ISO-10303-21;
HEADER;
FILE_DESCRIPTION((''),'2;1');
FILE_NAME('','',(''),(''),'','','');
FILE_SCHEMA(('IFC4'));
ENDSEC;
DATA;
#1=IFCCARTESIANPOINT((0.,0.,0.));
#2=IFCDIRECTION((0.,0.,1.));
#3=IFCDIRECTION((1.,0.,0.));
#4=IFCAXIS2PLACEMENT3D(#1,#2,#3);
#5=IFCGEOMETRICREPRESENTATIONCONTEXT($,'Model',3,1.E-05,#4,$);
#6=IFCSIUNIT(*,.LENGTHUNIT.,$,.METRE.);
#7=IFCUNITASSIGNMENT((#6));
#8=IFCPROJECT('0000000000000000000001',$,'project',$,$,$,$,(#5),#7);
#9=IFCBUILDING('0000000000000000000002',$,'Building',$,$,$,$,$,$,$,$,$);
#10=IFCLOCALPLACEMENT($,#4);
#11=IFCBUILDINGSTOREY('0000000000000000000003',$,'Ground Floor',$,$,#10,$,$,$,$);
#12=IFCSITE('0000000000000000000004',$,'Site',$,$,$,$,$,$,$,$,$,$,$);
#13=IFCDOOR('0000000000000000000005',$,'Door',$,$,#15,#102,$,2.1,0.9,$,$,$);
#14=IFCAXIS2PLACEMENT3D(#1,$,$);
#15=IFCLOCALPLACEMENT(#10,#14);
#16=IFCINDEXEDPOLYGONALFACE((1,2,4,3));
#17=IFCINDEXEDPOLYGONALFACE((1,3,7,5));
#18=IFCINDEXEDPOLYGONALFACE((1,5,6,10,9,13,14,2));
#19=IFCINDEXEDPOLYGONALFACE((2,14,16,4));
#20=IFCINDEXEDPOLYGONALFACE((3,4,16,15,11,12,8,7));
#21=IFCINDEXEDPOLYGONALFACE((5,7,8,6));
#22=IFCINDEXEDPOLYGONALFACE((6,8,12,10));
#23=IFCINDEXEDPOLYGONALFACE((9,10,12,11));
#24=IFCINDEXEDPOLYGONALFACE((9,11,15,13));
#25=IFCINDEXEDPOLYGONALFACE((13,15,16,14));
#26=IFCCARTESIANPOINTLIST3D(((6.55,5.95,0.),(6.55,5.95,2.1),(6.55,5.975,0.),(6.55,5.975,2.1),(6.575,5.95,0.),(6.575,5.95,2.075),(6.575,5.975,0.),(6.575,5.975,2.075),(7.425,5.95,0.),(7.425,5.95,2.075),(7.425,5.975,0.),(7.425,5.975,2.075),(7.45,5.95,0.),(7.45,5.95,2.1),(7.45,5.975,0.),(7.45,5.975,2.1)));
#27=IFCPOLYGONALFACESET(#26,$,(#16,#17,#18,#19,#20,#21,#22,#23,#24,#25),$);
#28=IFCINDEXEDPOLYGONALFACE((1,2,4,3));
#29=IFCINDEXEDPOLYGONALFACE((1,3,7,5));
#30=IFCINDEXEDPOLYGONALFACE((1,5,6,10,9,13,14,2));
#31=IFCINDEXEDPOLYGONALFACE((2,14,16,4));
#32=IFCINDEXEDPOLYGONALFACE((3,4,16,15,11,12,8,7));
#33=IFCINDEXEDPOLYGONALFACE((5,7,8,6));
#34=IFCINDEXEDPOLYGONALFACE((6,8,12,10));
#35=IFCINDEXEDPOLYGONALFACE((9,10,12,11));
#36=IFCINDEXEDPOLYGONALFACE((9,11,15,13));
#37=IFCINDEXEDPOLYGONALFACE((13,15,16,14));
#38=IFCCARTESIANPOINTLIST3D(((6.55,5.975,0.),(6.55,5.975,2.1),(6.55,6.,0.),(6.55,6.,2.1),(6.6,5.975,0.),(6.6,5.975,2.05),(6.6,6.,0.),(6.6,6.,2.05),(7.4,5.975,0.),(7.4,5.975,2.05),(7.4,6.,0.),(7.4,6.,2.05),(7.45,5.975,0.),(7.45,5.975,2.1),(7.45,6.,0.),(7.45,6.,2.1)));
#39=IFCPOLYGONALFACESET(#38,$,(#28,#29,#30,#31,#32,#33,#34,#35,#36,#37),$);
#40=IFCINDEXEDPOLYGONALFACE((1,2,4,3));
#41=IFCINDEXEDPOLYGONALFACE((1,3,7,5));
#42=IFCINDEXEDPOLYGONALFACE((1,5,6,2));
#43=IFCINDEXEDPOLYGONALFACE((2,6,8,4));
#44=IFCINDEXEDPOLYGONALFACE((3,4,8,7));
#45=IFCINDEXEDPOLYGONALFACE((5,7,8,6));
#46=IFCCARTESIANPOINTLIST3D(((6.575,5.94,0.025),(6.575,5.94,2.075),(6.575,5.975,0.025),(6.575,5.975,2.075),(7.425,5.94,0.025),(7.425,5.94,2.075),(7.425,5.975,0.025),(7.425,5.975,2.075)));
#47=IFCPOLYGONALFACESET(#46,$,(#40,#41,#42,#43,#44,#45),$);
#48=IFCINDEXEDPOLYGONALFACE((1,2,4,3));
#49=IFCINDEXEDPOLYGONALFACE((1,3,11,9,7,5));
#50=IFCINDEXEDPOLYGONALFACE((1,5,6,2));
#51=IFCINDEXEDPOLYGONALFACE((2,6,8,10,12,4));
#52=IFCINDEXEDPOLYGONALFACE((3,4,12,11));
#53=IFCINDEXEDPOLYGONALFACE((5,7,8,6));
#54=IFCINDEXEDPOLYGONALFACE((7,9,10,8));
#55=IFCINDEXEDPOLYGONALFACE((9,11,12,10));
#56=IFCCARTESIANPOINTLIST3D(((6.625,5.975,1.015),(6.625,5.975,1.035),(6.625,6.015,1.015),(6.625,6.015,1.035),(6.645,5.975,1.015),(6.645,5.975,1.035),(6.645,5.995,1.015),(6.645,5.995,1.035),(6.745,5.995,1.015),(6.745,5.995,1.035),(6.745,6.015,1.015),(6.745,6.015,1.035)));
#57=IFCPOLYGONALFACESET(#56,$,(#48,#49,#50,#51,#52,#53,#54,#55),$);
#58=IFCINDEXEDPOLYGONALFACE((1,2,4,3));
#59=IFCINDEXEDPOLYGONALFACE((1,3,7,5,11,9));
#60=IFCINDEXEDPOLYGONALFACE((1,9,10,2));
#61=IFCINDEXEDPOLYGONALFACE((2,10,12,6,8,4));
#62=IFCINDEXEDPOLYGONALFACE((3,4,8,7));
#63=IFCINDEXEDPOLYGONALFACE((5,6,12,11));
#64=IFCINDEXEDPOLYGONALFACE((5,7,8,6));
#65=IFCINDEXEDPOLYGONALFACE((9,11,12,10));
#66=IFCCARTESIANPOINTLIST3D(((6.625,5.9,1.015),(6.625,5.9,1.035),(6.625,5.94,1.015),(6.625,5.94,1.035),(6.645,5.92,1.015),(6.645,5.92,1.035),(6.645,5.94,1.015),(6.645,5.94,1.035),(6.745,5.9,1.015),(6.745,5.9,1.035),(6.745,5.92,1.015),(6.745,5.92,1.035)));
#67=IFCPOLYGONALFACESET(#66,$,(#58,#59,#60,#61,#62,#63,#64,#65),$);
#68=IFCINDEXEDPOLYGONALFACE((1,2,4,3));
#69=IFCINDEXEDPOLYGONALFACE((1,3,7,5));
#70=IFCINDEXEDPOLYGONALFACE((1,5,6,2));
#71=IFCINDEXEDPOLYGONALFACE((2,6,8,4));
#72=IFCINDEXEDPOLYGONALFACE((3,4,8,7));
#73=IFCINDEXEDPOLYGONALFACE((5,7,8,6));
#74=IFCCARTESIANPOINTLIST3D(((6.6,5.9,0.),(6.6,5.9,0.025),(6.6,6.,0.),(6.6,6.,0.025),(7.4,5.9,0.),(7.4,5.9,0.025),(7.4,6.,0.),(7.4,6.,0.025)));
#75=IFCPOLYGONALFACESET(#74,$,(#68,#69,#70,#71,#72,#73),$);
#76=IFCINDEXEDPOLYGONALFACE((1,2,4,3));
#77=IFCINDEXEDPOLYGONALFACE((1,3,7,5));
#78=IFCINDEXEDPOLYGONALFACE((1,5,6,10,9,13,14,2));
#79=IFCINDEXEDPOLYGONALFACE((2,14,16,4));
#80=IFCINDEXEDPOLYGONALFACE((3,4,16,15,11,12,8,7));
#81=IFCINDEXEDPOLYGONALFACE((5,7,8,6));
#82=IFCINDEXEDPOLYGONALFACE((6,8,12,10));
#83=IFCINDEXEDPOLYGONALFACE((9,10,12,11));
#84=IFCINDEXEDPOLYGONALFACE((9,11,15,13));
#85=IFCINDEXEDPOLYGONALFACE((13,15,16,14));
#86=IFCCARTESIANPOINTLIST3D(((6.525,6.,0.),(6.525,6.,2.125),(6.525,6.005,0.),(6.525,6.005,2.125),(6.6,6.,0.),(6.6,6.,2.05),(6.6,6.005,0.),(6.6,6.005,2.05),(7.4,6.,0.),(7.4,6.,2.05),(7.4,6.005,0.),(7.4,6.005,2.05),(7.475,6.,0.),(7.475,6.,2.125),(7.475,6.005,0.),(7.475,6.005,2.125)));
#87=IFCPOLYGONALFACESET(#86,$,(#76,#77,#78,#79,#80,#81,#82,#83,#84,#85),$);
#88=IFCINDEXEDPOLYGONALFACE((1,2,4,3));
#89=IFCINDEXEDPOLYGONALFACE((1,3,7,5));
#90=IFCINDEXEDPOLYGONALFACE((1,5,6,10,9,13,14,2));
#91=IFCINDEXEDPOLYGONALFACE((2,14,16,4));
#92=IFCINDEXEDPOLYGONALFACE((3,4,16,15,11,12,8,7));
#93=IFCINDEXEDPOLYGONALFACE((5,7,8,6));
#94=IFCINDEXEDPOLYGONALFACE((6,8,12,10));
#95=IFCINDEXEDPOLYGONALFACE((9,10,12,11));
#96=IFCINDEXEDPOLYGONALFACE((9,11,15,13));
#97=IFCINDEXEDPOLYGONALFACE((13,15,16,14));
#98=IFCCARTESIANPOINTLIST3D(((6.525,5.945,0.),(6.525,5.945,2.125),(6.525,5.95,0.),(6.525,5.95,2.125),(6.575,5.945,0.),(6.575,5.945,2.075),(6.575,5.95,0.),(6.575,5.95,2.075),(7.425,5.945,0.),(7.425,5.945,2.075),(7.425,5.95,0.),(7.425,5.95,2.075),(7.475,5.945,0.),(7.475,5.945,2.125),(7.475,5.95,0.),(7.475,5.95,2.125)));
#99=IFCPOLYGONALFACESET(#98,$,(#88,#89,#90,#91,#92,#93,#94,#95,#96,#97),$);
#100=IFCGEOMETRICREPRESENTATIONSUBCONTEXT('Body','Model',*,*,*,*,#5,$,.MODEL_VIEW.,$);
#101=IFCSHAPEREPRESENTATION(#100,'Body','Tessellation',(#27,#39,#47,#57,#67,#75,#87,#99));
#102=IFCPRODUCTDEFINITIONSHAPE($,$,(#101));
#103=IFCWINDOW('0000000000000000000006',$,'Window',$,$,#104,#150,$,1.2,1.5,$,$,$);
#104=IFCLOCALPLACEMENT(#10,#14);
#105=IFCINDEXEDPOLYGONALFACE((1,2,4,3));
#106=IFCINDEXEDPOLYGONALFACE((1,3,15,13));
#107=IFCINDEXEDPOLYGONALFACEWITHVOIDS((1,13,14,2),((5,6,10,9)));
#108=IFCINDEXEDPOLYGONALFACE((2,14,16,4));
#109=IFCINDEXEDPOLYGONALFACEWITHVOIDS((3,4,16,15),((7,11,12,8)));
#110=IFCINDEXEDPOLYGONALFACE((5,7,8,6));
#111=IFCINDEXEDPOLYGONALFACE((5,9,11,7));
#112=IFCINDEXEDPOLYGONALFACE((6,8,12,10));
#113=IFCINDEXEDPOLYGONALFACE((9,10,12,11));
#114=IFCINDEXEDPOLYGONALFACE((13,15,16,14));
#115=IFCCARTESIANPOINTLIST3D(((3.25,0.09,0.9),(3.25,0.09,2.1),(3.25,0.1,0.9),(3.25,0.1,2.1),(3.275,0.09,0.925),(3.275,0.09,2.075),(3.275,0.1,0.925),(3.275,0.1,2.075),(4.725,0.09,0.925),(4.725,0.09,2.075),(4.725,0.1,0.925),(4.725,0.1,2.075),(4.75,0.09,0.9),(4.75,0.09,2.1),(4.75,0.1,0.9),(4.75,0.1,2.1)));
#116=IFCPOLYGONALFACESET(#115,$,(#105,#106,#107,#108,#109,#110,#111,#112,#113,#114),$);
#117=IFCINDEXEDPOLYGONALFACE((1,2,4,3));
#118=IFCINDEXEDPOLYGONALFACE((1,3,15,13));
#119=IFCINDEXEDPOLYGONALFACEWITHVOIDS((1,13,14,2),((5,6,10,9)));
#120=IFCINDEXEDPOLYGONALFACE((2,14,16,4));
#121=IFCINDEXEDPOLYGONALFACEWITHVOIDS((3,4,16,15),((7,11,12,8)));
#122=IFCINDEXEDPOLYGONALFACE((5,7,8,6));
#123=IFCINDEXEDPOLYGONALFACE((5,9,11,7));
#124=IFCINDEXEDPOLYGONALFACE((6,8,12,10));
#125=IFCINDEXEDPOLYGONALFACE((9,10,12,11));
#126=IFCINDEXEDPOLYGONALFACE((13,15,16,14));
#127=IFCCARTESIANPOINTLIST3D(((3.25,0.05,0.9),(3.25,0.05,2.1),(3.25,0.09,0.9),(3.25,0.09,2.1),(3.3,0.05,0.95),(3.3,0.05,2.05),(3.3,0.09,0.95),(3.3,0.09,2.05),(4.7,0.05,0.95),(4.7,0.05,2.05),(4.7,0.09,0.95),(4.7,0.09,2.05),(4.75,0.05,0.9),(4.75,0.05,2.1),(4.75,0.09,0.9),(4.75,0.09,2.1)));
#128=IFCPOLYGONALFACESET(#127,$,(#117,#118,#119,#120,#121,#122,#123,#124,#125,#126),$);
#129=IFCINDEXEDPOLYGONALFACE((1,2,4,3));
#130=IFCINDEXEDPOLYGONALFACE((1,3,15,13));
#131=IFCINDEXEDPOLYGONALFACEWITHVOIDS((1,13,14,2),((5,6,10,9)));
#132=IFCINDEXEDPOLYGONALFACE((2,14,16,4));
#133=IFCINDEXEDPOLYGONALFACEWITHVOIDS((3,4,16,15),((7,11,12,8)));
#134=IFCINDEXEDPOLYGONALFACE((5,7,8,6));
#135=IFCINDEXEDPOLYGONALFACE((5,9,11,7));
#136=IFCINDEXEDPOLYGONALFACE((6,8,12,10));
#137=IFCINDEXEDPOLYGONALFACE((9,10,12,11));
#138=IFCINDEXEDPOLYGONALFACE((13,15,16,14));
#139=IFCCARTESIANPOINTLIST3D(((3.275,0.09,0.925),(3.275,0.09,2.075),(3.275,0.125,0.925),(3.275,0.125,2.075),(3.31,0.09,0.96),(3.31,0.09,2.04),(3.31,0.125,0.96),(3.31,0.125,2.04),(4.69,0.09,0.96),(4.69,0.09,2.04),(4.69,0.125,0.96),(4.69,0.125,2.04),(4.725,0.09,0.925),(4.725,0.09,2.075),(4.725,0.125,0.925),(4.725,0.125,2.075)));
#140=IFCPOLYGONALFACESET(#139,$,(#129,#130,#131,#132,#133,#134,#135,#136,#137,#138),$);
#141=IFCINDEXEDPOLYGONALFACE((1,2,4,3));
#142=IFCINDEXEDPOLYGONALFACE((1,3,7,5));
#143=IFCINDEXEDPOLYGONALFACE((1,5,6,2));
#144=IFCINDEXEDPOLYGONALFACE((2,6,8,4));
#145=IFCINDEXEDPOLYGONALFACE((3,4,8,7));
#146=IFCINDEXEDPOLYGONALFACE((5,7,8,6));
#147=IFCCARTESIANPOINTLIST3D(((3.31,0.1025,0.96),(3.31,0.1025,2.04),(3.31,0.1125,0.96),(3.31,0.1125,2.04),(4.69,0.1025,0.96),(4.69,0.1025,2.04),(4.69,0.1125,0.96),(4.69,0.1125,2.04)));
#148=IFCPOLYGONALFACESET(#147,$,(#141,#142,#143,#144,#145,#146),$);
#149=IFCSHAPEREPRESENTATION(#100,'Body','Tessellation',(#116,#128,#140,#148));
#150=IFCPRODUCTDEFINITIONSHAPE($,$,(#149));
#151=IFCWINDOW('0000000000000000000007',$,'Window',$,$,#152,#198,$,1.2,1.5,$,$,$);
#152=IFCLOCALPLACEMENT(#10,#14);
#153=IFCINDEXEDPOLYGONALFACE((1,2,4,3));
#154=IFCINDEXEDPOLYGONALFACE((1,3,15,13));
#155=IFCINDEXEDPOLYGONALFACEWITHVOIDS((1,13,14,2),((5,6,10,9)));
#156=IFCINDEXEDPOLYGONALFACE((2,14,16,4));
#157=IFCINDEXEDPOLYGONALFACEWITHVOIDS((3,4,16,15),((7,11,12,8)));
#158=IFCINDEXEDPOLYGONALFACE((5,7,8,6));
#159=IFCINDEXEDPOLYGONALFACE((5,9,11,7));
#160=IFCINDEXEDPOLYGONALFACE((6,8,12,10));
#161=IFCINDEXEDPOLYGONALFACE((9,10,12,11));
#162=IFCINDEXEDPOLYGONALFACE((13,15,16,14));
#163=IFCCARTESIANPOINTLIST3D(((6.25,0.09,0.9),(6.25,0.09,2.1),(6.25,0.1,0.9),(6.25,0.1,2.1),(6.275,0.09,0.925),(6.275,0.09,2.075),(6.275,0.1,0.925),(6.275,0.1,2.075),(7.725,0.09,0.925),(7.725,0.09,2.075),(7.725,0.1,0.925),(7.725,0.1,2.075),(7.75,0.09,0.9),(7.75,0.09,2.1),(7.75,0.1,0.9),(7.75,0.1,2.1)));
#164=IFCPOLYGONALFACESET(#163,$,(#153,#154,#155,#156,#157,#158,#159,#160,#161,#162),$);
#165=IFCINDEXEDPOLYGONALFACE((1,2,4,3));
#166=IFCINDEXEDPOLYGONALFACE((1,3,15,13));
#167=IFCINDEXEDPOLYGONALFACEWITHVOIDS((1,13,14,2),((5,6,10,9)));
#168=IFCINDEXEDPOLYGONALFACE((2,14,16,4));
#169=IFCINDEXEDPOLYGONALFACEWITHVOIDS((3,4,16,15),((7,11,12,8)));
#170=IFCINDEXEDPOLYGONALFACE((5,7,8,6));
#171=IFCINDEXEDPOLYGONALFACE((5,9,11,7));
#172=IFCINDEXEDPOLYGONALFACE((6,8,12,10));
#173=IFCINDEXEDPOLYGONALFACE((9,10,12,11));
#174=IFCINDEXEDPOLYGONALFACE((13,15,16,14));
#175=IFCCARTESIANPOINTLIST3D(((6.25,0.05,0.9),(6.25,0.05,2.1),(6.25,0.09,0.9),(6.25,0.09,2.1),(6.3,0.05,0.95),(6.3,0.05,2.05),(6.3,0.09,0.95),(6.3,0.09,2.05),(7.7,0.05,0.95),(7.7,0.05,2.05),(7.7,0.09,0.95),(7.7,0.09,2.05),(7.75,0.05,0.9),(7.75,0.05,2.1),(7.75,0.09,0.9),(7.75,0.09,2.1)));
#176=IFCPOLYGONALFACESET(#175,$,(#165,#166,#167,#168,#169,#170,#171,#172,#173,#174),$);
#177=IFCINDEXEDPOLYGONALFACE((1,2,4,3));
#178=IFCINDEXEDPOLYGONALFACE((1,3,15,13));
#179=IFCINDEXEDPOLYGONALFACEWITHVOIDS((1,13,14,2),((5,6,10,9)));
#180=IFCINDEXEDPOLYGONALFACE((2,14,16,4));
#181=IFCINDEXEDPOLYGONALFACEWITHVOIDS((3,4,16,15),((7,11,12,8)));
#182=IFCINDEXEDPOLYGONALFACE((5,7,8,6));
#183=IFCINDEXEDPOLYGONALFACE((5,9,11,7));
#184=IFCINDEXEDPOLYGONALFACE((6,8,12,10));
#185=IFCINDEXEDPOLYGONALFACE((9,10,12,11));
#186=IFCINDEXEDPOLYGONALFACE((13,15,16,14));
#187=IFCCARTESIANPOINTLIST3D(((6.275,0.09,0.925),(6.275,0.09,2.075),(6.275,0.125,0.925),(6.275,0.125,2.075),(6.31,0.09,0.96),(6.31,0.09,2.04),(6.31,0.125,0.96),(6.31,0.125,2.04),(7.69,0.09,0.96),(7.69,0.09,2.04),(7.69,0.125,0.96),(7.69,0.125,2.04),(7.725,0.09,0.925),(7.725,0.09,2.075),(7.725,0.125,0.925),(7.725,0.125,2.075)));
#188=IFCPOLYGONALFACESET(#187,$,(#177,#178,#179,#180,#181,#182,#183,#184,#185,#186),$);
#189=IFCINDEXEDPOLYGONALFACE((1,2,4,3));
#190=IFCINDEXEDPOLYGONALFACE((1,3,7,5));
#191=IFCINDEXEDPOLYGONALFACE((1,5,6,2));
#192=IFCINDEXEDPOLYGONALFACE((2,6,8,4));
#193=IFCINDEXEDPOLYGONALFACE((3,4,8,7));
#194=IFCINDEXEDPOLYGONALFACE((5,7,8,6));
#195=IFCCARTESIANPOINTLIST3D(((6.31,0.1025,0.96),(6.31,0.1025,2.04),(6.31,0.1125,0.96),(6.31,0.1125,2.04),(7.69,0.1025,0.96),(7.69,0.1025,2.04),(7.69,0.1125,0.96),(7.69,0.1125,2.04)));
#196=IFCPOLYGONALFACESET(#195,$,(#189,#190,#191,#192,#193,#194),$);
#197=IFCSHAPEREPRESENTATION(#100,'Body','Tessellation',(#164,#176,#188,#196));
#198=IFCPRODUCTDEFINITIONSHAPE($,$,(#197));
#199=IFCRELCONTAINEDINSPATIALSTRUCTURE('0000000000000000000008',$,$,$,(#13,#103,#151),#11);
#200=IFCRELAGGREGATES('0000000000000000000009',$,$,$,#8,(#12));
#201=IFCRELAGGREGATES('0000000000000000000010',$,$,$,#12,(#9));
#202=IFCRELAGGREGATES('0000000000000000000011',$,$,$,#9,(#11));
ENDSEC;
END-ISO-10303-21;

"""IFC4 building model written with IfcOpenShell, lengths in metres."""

from ifc_helpers import new_model, si_unit, frame, origin_with_axes, place, context, subcontext, project, spatial, line, indexed_curve, outline, extrude, element, save


model = new_model("IFC4")

# Units and contexts
model_context = context("Model", 3, precision=1e-05, world=origin_with_axes())
body_context = subcontext(model_context, "Body", "Model", "MODEL_VIEW")
ifc_project = project(units=[si_unit("LENGTHUNIT", "METRE")], contexts=[model_context])

# Site, building, storey
site = spatial("IfcSite", under=ifc_project, Name="Site")
building = spatial("IfcBuilding", under=site, Name="Building")
storey_placement = place(None, origin_with_axes())
storey = spatial("IfcBuildingStorey", under=building, at=storey_placement, Name="Ground Floor")

# Door
door_1_placement = place(storey_placement, frame((7.45, 6.0, 0.0), z_axis=(0.0, 0.0, 1.0), x_axis=(-1.0, 0.0, 0.0)))
element("IfcDoor", 1, at=door_1_placement, inside=storey, Name="Door", OverallHeight=2.1, OverallWidth=0.9, context=body_context, shape_type="SweptSolid", body=[
    extrude(outline(indexed_curve([(0.0, 0.0), (0.0, 2.1), (0.9, 2.1), (0.9, 0.0), (0.875, 0.0), (0.875, 2.075), (0.025, 2.075), (0.025, 0.0)], segments=[line(1, 2, 3, 4, 5, 6, 7, 8, 1)])), frame((0.0, 0.025, 0.0), z_axis=(0.0, -1.0, 0.0), x_axis=(1.0, 0.0, 0.0)), (0.0, 0.0, -1.0), 0.025),
    extrude(outline(indexed_curve([(0.0, 0.0), (0.0, 2.1), (0.9, 2.1), (0.9, 0.0), (0.85, 0.0), (0.85, 2.05), (0.05, 2.05), (0.05, 0.0)], segments=[line(1, 2, 3, 4, 5, 6, 7, 8, 1)])), frame((0.0, 0.0, 0.0), z_axis=(0.0, -1.0, 0.0), x_axis=(1.0, 0.0, 0.0)), (0.0, 0.0, -1.0), 0.025),
    extrude(outline(indexed_curve([(0.0, 0.0), (0.85, 0.0), (0.85, 0.035), (0.0, 0.035)], segments=[line(1, 2, 3, 4, 1)])), frame((0.025, 0.025, 0.025), z_axis=(0.0, 0.0, 1.0), x_axis=(1.0, 0.0, 0.0)), (0.0, 0.0, 1.0), 2.05),
    extrude(outline(indexed_curve([(0.0, 0.0), (0.0, -0.04), (-0.12, -0.04), (-0.12, -0.02), (-0.02, -0.02), (-0.02, 0.0)], segments=[line(1, 2, 3, 4, 5, 6, 1)])), frame((0.825, 0.025, 1.015), z_axis=(0.0, 0.0, 1.0), x_axis=(1.0, 0.0, 0.0)), (0.0, 0.0, 1.0), 0.02),
    extrude(outline(indexed_curve([(0.0, 0.0), (0.0, 0.04), (-0.12, 0.04), (-0.12, 0.02), (-0.02, 0.02), (-0.02, 0.0)], segments=[line(1, 2, 3, 4, 5, 6, 1)])), frame((0.825, 0.06, 1.015), z_axis=(0.0, 0.0, 1.0), x_axis=(1.0, 0.0, 0.0)), (0.0, 0.0, 1.0), 0.02),
    extrude(outline(indexed_curve([(0.0, 0.0), (0.8, 0.0), (0.8, 0.1), (0.0, 0.1)], segments=[line(1, 2, 3, 4, 1)])), frame((0.05, 0.0, 0.0), z_axis=(0.0, 0.0, 1.0), x_axis=(1.0, 0.0, 0.0)), (0.0, 0.0, 1.0), 0.025),
    extrude(outline(indexed_curve([(0.0, 0.0), (0.0, 2.125), (0.95, 2.125), (0.95, 0.0), (0.875, 0.0), (0.875, 2.05), (0.075, 2.05), (0.075, 0.0)], segments=[line(1, 2, 3, 4, 5, 6, 7, 8, 1)])), frame((-0.025, -0.005, 0.0), z_axis=(0.0, -1.0, 0.0), x_axis=(1.0, 0.0, 0.0)), (0.0, 0.0, -1.0), 0.005),
    extrude(outline(indexed_curve([(0.0, 0.0), (0.0, 2.125), (0.95, 2.125), (0.95, 0.0), (0.9, 0.0), (0.9, 2.075), (0.05, 2.075), (0.05, 0.0)], segments=[line(1, 2, 3, 4, 5, 6, 7, 8, 1)])), frame((-0.025, 0.05, 0.0), z_axis=(0.0, -1.0, 0.0), x_axis=(1.0, 0.0, 0.0)), (0.0, 0.0, -1.0), 0.005),
])

# Windows
for number, where, z_axis, x_axis, name in (
    (2, (3.25, 0.0, 0.9), (0.0, 0.0, 1.0), (1.0, 0.0, 0.0), "Window"),
    (3, (6.25, 0.0, 0.9), (0.0, 0.0, 1.0), (1.0, 0.0, 0.0), "Window"),
):
    element("IfcWindow", number, at=place(storey_placement, frame(where, z_axis=z_axis, x_axis=x_axis)), inside=storey, Name=name, OverallHeight=1.2, OverallWidth=1.5, context=body_context, shape_type="SweptSolid", body=[
        extrude(outline(indexed_curve([(0.0, 0.0), (1.5, 0.0), (1.5, 1.2), (0.0, 1.2)], segments=[line(1, 2, 3, 4, 1)]), holes=[indexed_curve([(0.025, 0.025), (1.475, 0.025), (1.475, 1.175), (0.025, 1.175)], segments=[line(1, 2, 3, 4, 1)])]), frame((0.0, 0.09, 0.0), z_axis=(0.0, -1.0, 0.0), x_axis=(1.0, 0.0, 0.0)), (0.0, 0.0, -1.0), 0.01),
        extrude(outline(indexed_curve([(0.0, 0.0), (1.5, 0.0), (1.5, 1.2), (0.0, 1.2)], segments=[line(1, 2, 3, 4, 1)]), holes=[indexed_curve([(0.05, 0.05), (1.45, 0.05), (1.45, 1.15), (0.05, 1.15)], segments=[line(1, 2, 3, 4, 1)])]), frame((0.0, 0.05, 0.0), z_axis=(0.0, -1.0, 0.0), x_axis=(1.0, 0.0, 0.0)), (0.0, 0.0, -1.0), 0.04),
        extrude(outline(indexed_curve([(0.0, 0.0), (1.45, 0.0), (1.45, 1.15), (0.0, 1.15)], segments=[line(1, 2, 3, 4, 1)]), holes=[indexed_curve([(0.035, 0.035), (1.415, 0.035), (1.415, 1.115), (0.035, 1.115)], segments=[line(1, 2, 3, 4, 1)])]), frame((0.025, 0.09, 0.025), z_axis=(0.0, -1.0, 0.0), x_axis=(1.0, 0.0, 0.0)), (0.0, 0.0, -1.0), 0.035),
        extrude(outline(indexed_curve([(0.035, 0.035), (1.415, 0.035), (1.415, 1.115), (0.035, 1.115)], segments=[line(1, 2, 3, 4, 1)])), frame((0.025, 0.1025, 0.025), z_axis=(0.0, -1.0, 0.0), x_axis=(1.0, 0.0, 0.0)), (0.0, 0.0, -1.0), 0.01),
    ])

save(model, "model.ifc")
